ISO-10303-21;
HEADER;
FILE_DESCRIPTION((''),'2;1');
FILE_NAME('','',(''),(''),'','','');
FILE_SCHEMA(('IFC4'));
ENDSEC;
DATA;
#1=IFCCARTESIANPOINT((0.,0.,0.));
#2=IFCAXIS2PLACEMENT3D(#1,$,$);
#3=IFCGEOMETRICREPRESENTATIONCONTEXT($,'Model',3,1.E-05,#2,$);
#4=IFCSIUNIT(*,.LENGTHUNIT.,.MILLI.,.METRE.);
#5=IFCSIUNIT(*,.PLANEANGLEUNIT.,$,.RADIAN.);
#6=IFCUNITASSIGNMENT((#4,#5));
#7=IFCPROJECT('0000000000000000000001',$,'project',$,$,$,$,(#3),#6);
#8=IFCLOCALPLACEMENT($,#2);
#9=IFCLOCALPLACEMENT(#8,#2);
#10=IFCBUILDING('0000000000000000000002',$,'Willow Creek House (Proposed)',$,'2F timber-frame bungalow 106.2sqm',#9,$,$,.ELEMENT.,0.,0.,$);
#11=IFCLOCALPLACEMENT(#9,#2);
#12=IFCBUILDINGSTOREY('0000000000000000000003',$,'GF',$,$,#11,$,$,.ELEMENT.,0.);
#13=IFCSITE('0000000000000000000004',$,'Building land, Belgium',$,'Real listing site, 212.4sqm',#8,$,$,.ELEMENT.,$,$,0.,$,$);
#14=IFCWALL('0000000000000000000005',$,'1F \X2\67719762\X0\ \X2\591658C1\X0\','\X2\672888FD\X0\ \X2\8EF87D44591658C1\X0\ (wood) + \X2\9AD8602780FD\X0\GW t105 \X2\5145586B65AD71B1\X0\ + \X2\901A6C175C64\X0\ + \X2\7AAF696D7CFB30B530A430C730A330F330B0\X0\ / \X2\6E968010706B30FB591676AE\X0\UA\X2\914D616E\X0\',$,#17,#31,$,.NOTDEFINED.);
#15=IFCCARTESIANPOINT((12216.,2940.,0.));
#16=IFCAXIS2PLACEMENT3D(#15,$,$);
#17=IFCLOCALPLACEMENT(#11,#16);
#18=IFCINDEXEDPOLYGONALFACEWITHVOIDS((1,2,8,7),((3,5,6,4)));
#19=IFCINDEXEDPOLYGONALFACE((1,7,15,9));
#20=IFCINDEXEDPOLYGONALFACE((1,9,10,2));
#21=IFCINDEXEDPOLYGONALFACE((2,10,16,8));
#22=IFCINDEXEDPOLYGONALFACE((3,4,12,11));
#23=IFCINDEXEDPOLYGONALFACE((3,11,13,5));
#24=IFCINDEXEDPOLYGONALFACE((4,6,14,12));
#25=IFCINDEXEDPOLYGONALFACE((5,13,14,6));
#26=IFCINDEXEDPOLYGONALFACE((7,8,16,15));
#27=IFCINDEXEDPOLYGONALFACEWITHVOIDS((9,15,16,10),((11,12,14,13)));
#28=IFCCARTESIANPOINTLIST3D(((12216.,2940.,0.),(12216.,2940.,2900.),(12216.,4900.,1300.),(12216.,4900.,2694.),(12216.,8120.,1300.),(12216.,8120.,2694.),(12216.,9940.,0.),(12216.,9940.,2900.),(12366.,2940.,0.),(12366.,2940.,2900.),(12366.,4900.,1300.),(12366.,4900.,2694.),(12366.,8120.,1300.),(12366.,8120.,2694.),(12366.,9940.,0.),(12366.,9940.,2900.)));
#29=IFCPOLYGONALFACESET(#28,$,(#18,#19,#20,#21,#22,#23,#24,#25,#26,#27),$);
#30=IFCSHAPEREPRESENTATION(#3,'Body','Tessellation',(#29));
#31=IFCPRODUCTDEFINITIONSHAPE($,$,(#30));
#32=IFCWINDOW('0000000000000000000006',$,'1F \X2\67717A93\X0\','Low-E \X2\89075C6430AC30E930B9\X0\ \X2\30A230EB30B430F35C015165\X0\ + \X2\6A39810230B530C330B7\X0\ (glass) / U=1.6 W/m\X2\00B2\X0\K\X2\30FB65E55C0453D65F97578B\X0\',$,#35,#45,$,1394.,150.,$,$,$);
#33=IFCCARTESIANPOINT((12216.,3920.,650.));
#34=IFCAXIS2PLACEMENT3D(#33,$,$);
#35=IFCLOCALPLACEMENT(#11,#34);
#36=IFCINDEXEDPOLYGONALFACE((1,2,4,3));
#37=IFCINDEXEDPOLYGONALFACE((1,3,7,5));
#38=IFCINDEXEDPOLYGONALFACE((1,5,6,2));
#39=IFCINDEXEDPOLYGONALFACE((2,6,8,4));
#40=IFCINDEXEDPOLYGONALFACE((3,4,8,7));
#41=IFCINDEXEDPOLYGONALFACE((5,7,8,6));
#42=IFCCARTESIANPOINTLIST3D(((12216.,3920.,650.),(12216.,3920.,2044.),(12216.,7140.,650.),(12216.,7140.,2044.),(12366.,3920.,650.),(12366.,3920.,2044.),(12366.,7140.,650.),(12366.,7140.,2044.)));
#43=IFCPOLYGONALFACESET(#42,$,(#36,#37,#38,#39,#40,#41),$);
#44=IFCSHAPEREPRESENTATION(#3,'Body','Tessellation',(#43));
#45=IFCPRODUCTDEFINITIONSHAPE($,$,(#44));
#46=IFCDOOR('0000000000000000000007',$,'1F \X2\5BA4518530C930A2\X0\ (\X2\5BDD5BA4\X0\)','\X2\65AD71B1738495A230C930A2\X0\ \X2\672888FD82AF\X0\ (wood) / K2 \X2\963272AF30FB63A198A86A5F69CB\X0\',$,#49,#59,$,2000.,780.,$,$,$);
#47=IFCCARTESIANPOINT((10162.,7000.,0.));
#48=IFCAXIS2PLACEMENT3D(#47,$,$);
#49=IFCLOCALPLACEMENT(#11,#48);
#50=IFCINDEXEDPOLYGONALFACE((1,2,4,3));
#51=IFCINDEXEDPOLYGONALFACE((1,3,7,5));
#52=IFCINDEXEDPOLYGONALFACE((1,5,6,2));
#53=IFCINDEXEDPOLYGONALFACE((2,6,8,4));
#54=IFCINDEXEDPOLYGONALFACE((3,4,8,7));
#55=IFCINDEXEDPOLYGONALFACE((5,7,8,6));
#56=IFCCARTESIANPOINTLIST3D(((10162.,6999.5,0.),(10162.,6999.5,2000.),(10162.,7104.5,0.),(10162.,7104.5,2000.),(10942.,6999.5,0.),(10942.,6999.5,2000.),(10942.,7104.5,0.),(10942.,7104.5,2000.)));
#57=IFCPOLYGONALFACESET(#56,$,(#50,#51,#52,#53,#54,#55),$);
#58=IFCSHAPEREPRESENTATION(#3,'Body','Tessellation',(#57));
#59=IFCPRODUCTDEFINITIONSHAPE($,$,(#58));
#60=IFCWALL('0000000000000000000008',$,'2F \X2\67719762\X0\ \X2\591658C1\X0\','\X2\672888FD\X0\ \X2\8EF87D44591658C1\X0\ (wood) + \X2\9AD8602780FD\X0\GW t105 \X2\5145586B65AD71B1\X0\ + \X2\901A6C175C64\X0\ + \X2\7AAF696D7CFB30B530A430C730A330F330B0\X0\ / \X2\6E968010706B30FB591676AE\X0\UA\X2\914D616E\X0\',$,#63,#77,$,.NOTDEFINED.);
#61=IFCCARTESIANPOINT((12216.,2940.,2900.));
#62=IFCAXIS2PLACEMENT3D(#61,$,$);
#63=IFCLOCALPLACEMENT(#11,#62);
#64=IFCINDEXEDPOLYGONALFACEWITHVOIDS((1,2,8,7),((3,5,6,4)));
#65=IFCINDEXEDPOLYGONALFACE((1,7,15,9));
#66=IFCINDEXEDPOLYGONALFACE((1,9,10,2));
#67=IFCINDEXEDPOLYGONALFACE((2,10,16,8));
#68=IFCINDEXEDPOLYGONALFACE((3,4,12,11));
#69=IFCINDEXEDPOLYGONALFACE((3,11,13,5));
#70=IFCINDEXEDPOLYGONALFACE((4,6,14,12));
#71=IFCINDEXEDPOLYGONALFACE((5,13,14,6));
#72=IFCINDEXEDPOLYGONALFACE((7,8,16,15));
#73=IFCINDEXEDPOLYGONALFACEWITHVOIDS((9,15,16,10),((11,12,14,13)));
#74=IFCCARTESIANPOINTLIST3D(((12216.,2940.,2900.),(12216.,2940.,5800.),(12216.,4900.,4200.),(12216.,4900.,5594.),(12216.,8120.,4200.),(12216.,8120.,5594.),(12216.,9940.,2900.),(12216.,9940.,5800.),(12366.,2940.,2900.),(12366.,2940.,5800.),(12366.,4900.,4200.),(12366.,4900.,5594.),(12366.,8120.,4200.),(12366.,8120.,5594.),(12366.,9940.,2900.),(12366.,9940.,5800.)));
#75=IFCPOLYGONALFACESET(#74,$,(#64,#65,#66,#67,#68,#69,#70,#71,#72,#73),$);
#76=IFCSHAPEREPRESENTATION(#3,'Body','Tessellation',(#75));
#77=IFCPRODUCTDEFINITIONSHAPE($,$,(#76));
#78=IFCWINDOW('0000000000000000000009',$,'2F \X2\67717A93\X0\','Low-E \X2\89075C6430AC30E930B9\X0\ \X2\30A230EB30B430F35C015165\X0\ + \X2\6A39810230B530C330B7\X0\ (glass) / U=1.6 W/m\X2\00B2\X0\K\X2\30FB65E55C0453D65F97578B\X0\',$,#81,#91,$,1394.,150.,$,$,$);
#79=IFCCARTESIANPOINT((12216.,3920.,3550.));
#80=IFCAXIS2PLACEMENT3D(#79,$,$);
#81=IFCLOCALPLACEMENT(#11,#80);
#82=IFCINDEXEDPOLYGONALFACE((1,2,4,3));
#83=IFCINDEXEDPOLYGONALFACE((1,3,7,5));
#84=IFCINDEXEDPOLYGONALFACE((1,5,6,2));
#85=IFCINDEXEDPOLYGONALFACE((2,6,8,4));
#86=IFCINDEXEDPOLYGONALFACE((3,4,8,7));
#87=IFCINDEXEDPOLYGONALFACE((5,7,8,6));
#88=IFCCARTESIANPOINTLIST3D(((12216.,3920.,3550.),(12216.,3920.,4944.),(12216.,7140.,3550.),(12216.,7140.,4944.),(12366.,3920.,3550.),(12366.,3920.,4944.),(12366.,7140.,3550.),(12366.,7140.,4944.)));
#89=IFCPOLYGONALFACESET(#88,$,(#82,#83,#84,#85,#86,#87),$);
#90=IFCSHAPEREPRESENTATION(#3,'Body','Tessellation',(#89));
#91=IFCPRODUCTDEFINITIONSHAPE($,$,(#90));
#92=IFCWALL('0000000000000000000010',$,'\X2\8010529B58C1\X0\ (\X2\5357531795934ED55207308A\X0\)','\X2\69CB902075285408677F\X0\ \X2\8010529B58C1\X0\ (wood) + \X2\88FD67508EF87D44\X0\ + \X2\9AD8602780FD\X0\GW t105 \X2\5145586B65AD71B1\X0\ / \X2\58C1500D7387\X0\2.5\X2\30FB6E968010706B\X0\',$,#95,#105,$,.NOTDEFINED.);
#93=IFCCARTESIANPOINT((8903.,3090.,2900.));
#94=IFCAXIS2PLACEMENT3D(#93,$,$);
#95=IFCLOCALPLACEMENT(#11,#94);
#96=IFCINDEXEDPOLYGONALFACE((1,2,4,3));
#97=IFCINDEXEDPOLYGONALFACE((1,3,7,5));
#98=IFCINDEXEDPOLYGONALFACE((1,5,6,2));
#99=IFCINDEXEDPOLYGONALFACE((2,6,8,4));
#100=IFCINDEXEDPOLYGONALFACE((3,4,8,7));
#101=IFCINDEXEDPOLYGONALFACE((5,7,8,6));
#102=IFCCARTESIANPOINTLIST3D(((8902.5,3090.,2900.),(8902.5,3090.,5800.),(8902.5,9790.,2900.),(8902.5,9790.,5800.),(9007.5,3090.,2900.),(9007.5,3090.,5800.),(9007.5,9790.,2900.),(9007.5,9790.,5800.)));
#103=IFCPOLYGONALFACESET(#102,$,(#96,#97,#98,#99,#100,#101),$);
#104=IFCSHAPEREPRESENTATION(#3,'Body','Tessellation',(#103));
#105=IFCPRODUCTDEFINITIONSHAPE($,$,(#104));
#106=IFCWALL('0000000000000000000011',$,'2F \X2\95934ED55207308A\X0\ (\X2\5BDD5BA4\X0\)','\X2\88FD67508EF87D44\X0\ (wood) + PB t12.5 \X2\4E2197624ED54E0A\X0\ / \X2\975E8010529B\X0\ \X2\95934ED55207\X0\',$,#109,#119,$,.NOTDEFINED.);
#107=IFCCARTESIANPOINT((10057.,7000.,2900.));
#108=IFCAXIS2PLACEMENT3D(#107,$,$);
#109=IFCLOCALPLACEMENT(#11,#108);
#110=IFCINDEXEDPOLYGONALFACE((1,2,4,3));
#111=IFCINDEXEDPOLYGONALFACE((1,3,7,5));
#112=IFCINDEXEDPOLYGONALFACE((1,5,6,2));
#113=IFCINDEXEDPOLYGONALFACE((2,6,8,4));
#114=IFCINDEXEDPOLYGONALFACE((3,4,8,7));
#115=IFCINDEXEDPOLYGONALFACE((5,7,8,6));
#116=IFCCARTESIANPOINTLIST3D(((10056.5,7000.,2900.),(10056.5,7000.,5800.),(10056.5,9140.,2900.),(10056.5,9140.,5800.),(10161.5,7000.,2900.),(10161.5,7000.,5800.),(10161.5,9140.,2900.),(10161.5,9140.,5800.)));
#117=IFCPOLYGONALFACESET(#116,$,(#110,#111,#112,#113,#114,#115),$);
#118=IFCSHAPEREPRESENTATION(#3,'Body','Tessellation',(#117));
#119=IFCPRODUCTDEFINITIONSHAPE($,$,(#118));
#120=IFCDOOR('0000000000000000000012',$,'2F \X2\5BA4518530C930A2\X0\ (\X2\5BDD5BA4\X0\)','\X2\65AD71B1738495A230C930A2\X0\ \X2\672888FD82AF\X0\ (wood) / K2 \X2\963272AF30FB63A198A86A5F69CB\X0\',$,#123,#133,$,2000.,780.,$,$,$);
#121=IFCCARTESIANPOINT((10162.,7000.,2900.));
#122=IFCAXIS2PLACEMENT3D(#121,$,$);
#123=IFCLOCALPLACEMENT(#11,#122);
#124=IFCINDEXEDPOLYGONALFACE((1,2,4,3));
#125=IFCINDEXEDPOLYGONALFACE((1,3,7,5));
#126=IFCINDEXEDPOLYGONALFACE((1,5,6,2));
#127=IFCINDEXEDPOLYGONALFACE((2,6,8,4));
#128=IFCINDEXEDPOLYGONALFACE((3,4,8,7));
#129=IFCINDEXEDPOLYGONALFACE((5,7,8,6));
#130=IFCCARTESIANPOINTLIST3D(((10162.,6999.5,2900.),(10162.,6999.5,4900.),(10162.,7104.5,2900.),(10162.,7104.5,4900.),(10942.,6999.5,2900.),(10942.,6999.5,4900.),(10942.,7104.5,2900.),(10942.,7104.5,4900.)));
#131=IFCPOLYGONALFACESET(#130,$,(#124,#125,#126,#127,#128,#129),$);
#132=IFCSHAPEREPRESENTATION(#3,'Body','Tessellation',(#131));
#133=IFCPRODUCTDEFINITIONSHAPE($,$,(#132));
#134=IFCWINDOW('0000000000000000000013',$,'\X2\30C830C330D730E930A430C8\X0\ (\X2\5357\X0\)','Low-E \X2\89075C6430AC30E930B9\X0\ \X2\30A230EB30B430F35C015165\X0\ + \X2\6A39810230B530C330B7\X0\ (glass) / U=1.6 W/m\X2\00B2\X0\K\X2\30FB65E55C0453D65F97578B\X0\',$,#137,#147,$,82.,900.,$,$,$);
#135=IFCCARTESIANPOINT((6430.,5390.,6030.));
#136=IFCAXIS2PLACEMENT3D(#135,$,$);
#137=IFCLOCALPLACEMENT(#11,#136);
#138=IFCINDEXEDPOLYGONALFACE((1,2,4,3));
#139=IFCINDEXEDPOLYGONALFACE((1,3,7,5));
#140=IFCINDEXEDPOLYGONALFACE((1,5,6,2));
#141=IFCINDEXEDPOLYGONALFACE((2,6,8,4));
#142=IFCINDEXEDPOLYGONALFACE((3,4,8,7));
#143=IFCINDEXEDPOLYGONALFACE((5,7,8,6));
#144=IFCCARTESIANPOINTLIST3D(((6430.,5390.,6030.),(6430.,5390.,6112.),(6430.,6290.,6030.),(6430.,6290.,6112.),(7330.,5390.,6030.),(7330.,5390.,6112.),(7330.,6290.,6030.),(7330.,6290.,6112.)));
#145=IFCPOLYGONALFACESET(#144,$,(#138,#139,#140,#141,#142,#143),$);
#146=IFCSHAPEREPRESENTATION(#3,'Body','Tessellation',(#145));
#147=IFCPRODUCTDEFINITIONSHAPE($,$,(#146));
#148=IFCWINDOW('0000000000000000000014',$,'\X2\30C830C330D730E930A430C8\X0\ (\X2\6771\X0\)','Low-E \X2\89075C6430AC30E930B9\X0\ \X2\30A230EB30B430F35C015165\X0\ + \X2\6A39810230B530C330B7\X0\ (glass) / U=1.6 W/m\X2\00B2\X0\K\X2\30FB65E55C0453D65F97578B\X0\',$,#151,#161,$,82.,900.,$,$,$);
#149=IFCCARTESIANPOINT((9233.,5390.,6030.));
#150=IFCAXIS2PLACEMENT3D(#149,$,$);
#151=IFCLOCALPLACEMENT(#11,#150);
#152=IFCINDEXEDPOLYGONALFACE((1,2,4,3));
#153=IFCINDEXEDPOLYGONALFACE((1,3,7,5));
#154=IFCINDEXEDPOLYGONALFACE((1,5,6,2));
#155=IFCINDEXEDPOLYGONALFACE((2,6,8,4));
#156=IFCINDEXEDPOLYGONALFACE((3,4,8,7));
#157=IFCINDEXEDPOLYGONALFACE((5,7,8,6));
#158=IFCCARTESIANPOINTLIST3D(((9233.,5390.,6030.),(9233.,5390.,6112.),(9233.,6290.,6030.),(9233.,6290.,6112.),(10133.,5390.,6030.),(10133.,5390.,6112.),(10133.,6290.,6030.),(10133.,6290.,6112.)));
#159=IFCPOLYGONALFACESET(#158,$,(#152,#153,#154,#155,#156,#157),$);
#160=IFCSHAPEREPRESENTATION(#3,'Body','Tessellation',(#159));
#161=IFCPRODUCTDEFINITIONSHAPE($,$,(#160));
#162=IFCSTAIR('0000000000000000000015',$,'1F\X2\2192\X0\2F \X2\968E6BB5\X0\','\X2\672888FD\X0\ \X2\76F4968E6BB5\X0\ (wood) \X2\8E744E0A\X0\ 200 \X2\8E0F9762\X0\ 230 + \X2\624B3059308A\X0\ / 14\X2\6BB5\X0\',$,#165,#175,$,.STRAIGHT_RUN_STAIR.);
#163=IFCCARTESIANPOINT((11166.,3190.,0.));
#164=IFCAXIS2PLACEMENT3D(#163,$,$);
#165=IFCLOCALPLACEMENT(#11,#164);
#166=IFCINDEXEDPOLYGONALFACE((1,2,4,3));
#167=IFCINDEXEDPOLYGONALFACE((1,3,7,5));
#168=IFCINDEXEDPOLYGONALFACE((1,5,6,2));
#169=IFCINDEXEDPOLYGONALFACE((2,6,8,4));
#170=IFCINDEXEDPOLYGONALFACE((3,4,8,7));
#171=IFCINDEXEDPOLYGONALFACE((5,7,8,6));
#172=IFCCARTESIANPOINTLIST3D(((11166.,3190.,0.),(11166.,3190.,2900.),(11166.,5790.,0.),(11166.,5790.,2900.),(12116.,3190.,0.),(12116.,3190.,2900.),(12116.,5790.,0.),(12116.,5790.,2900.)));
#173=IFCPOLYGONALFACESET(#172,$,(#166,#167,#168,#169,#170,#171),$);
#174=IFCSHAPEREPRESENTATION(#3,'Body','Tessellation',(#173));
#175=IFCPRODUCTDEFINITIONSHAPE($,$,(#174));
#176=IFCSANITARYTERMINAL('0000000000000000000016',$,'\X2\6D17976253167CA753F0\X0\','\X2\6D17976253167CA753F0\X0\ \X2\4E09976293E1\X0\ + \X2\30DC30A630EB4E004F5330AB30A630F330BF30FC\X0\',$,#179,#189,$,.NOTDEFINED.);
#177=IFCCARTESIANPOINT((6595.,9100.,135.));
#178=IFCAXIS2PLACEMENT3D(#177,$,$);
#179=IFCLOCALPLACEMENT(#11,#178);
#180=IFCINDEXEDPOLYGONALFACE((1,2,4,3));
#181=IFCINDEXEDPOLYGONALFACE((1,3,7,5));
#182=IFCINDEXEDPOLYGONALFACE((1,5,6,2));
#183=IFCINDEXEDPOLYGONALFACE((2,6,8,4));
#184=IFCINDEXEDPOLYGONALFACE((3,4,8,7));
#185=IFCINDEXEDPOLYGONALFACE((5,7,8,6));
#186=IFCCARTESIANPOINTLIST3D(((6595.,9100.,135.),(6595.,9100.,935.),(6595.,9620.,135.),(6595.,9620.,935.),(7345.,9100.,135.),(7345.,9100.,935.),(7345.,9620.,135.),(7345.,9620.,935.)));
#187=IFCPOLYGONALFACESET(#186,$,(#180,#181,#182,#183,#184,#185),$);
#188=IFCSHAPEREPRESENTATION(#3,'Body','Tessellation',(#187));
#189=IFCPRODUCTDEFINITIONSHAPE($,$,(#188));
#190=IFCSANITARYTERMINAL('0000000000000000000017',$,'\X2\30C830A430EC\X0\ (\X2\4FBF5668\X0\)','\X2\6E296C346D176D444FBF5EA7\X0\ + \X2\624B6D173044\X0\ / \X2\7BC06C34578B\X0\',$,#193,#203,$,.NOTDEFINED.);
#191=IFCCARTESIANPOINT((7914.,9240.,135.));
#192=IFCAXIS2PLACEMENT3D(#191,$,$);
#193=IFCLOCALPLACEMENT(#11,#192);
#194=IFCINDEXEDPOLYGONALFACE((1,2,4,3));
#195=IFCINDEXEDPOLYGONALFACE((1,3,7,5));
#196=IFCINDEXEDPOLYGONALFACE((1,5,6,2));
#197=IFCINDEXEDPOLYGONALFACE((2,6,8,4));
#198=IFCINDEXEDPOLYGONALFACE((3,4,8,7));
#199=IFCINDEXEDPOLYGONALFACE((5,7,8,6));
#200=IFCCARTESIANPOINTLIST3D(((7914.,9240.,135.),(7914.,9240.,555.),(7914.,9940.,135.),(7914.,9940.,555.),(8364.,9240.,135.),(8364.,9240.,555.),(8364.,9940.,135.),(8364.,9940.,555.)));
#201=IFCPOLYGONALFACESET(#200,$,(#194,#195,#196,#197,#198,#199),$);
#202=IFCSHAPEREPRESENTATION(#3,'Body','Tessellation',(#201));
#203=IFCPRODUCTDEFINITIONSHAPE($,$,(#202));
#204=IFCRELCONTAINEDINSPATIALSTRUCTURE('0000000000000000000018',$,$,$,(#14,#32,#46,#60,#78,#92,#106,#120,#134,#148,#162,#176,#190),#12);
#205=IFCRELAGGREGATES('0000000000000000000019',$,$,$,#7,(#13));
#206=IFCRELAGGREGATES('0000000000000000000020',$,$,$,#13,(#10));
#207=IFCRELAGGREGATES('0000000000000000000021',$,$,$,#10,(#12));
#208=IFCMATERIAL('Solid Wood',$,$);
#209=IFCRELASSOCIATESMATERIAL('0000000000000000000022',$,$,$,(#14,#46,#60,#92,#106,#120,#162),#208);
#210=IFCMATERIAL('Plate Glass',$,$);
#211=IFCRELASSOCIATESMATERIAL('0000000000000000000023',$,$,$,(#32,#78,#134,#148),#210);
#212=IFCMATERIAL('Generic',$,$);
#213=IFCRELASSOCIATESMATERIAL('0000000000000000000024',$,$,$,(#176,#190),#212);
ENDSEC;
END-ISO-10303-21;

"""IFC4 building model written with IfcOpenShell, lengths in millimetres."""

from ifc_helpers import new_model, si_unit, frame, frame_2d, origin, place, context, project, spatial, rectangle, extrude, material, element, fill, save


model = new_model("IFC4")

# Units and contexts
model_context = context("Model", 3, precision=1e-05, world=origin())
ifc_project = project(units=[si_unit("LENGTHUNIT", "METRE", prefix="MILLI"), si_unit("PLANEANGLEUNIT", "RADIAN")], contexts=[model_context])

# Site, building, storey
site_placement = place(None, origin())
site = spatial("IfcSite", under=ifc_project, at=site_placement, Name="Building land, Belgium", ObjectType="Real listing site, 212.4sqm", CompositionType="ELEMENT", RefElevation=0.0)
building_placement = place(site_placement, origin())
building = spatial("IfcBuilding", under=site, at=building_placement, Name="Willow Creek House (Proposed)", ObjectType="2F timber-frame bungalow 106.2sqm", CompositionType="ELEMENT", ElevationOfRefHeight=0.0, ElevationOfTerrain=0.0)
storey_placement = place(building_placement, origin())
storey = spatial("IfcBuildingStorey", under=building, at=storey_placement, Name="GF", CompositionType="ELEMENT", Elevation=0.0)

# Wall, opening, window
ifc_material_1 = material(Name="Solid Wood")
wall_1_placement = place(storey_placement, frame((12216.0, 2940.0, 0.0)))
wall_1 = element("IfcWall", 1, at=wall_1_placement, inside=storey, material=ifc_material_1, Name="1F 東面 外壁", Description="木製 軸組外壁 (wood) + 高性能GW t105 充填断熱 + 通気層 + 窯業系サイディング / 準耐火・外皮UA配慮", PredefinedType="NOTDEFINED", context=model_context, shape_type="SweptSolid", body=[
    extrude(rectangle(XDim=150.0, YDim=7000.0, at=frame_2d((75.0, 3500.0))), frame((12216.0, 2940.0, 0.0)), (0.0, 0.0, 1.0), 2900.0),
])
opening_1_placement = place(storey_placement, frame((12216.0, 3920.0, 650.0)))
opening_1 = element("IfcOpeningElement", 2, at=opening_1_placement, cuts=wall_1, PredefinedType="NOTDEFINED", context=model_context, shape_type="SweptSolid", body=[
    extrude(rectangle(XDim=150.0, YDim=3220.0, at=frame_2d((75.0, 1610.0))), frame((12216.0, 3920.0, 650.0)), (0.0, 0.0, 1.0), 1394.0),
])
ifc_material_2 = material(Name="Plate Glass")
window_1_placement = place(storey_placement, frame((12216.0, 3920.0, 650.0)))
window_1 = element("IfcWindow", 3, at=window_1_placement, inside=storey, material=ifc_material_2, Name="1F 東窓", Description="Low-E 複層ガラス アルゴン封入 + 樹脂サッシ (glass) / U=1.6 W/m²K・日射取得型", OverallHeight=1394.0, OverallWidth=150.0, context=model_context, shape_type="SweptSolid", body=[
    extrude(rectangle(XDim=150.0, YDim=3220.0, at=frame_2d((75.0, 1610.0))), frame((12216.0, 3920.0, 650.0)), (0.0, 0.0, 1.0), 1394.0),
])
fill(opening_1, window_1)

# Door
door_1_placement = place(storey_placement, frame((10162.0, 7000.0, 0.0)))
element("IfcDoor", 4, at=door_1_placement, inside=storey, material=ifc_material_1, Name="1F 室内ドア (寝室)", Description="断熱玄関ドア 木製芯 (wood) / K2 防犯・採風機構", OverallHeight=2000.0, OverallWidth=780.0, context=model_context, shape_type="SweptSolid", body=[
    extrude(rectangle(XDim=780.0, YDim=105.0, at=frame_2d((390.0, 52.0))), frame((10162.0, 7000.0, 0.0)), (0.0, 0.0, 1.0), 2000.0),
])

# Wall, opening, window
wall_2_placement = place(storey_placement, frame((12216.0, 2940.0, 2900.0)))
wall_2 = element("IfcWall", 5, at=wall_2_placement, inside=storey, material=ifc_material_1, Name="2F 東面 外壁", Description="木製 軸組外壁 (wood) + 高性能GW t105 充填断熱 + 通気層 + 窯業系サイディング / 準耐火・外皮UA配慮", PredefinedType="NOTDEFINED", context=model_context, shape_type="SweptSolid", body=[
    extrude(rectangle(XDim=150.0, YDim=7000.0, at=frame_2d((75.0, 3500.0))), frame((12216.0, 2940.0, 2900.0)), (0.0, 0.0, 1.0), 2900.0),
])
opening_2_placement = place(storey_placement, frame((12216.0, 3920.0, 3550.0)))
opening_2 = element("IfcOpeningElement", 6, at=opening_2_placement, cuts=wall_2, PredefinedType="NOTDEFINED", context=model_context, shape_type="SweptSolid", body=[
    extrude(rectangle(XDim=150.0, YDim=3220.0, at=frame_2d((75.0, 1610.0))), frame((12216.0, 3920.0, 3550.0)), (0.0, 0.0, 1.0), 1394.0),
])
window_2_placement = place(storey_placement, frame((12216.0, 3920.0, 3550.0)))
window_2 = element("IfcWindow", 7, at=window_2_placement, inside=storey, material=ifc_material_2, Name="2F 東窓", Description="Low-E 複層ガラス アルゴン封入 + 樹脂サッシ (glass) / U=1.6 W/m²K・日射取得型", OverallHeight=1394.0, OverallWidth=150.0, context=model_context, shape_type="SweptSolid", body=[
    extrude(rectangle(XDim=150.0, YDim=3220.0, at=frame_2d((75.0, 1610.0))), frame((12216.0, 3920.0, 3550.0)), (0.0, 0.0, 1.0), 1394.0),
])
fill(opening_2, window_2)

# Walls
wall_3_placement = place(storey_placement, frame((8903.0, 3090.0, 2900.0)))
element("IfcWall", 8, at=wall_3_placement, inside=storey, material=ifc_material_1, Name="耐力壁 (南北間仕切り)", Description="構造用合板 耐力壁 (wood) + 製材軸組 + 高性能GW t105 充填断熱 / 壁倍率2.5・準耐火", PredefinedType="NOTDEFINED", context=model_context, shape_type="SweptSolid", body=[
    extrude(rectangle(XDim=105.0, YDim=6700.0, at=frame_2d((52.0, 3350.0))), frame((8903.0, 3090.0, 2900.0)), (0.0, 0.0, 1.0), 2900.0),
])
wall_4_placement = place(storey_placement, frame((10057.0, 7000.0, 2900.0)))
element("IfcWall", 9, at=wall_4_placement, inside=storey, material=ifc_material_1, Name="2F 間仕切り (寝室)", Description="製材軸組 (wood) + PB t12.5 両面仕上 / 非耐力 間仕切", PredefinedType="NOTDEFINED", context=model_context, shape_type="SweptSolid", body=[
    extrude(rectangle(XDim=105.0, YDim=2140.0, at=frame_2d((52.0, 1070.0))), frame((10057.0, 7000.0, 2900.0)), (0.0, 0.0, 1.0), 2900.0),
])

# Door
door_2_placement = place(storey_placement, frame((10162.0, 7000.0, 2900.0)))
element("IfcDoor", 10, at=door_2_placement, inside=storey, material=ifc_material_1, Name="2F 室内ドア (寝室)", Description="断熱玄関ドア 木製芯 (wood) / K2 防犯・採風機構", OverallHeight=2000.0, OverallWidth=780.0, context=model_context, shape_type="SweptSolid", body=[
    extrude(rectangle(XDim=780.0, YDim=105.0, at=frame_2d((390.0, 52.0))), frame((10162.0, 7000.0, 2900.0)), (0.0, 0.0, 1.0), 2000.0),
])

# Windows
window_3_placement = place(storey_placement, frame((6430.0, 5390.0, 6030.0)))
element("IfcWindow", 11, at=window_3_placement, inside=storey, material=ifc_material_2, Name="トップライト (南)", Description="Low-E 複層ガラス アルゴン封入 + 樹脂サッシ (glass) / U=1.6 W/m²K・日射取得型", OverallHeight=82.0, OverallWidth=900.0, context=model_context, shape_type="SweptSolid", body=[
    extrude(rectangle(XDim=900.0, YDim=900.0, at=frame_2d((450.0, 450.0))), frame((6430.0, 5390.0, 6030.0)), (0.0, 0.0, 1.0), 82.0),
])
window_4_placement = place(storey_placement, frame((9233.0, 5390.0, 6030.0)))
element("IfcWindow", 12, at=window_4_placement, inside=storey, material=ifc_material_2, Name="トップライト (東)", Description="Low-E 複層ガラス アルゴン封入 + 樹脂サッシ (glass) / U=1.6 W/m²K・日射取得型", OverallHeight=82.0, OverallWidth=900.0, context=model_context, shape_type="SweptSolid", body=[
    extrude(rectangle(XDim=900.0, YDim=900.0, at=frame_2d((450.0, 450.0))), frame((9233.0, 5390.0, 6030.0)), (0.0, 0.0, 1.0), 82.0),
])

# Stair
stair_placement = place(storey_placement, frame((11166.0, 3190.0, 0.0)))
element("IfcStair", 13, at=stair_placement, inside=storey, material=ifc_material_1, Name="1F→2F 階段", Description="木製 直階段 (wood) 蹴上 200 踏面 230 + 手すり / 14段", PredefinedType="STRAIGHT_RUN_STAIR", context=model_context, shape_type="SweptSolid", body=[
    extrude(rectangle(XDim=950.0, YDim=2600.0, at=frame_2d((475.0, 1300.0))), frame((11166.0, 3190.0, 0.0)), (0.0, 0.0, 1.0), 2900.0),
])

# Sanitary terminals
ifc_material_3 = material(Name="Generic")
sanitary_terminal_1_placement = place(storey_placement, frame((6595.0, 9100.0, 135.0)))
element("IfcSanitaryTerminal", 14, at=sanitary_terminal_1_placement, inside=storey, material=ifc_material_3, Name="洗面化粧台", Description="洗面化粧台 三面鏡 + ボウル一体カウンター", PredefinedType="NOTDEFINED", context=model_context, shape_type="SweptSolid", body=[
    extrude(rectangle(XDim=750.0, YDim=520.0, at=frame_2d((375.0, 260.0))), frame((6595.0, 9100.0, 135.0)), (0.0, 0.0, 1.0), 800.0),
])
sanitary_terminal_2_placement = place(storey_placement, frame((7914.0, 9240.0, 135.0)))
element("IfcSanitaryTerminal", 15, at=sanitary_terminal_2_placement, inside=storey, material=ifc_material_3, Name="トイレ (便器)", Description="温水洗浄便座 + 手洗い / 節水型", PredefinedType="NOTDEFINED", context=model_context, shape_type="SweptSolid", body=[
    extrude(rectangle(XDim=450.0, YDim=700.0, at=frame_2d((225.0, 350.0))), frame((7914.0, 9240.0, 135.0)), (0.0, 0.0, 1.0), 420.0),
])

save(model, "model.ifc")
